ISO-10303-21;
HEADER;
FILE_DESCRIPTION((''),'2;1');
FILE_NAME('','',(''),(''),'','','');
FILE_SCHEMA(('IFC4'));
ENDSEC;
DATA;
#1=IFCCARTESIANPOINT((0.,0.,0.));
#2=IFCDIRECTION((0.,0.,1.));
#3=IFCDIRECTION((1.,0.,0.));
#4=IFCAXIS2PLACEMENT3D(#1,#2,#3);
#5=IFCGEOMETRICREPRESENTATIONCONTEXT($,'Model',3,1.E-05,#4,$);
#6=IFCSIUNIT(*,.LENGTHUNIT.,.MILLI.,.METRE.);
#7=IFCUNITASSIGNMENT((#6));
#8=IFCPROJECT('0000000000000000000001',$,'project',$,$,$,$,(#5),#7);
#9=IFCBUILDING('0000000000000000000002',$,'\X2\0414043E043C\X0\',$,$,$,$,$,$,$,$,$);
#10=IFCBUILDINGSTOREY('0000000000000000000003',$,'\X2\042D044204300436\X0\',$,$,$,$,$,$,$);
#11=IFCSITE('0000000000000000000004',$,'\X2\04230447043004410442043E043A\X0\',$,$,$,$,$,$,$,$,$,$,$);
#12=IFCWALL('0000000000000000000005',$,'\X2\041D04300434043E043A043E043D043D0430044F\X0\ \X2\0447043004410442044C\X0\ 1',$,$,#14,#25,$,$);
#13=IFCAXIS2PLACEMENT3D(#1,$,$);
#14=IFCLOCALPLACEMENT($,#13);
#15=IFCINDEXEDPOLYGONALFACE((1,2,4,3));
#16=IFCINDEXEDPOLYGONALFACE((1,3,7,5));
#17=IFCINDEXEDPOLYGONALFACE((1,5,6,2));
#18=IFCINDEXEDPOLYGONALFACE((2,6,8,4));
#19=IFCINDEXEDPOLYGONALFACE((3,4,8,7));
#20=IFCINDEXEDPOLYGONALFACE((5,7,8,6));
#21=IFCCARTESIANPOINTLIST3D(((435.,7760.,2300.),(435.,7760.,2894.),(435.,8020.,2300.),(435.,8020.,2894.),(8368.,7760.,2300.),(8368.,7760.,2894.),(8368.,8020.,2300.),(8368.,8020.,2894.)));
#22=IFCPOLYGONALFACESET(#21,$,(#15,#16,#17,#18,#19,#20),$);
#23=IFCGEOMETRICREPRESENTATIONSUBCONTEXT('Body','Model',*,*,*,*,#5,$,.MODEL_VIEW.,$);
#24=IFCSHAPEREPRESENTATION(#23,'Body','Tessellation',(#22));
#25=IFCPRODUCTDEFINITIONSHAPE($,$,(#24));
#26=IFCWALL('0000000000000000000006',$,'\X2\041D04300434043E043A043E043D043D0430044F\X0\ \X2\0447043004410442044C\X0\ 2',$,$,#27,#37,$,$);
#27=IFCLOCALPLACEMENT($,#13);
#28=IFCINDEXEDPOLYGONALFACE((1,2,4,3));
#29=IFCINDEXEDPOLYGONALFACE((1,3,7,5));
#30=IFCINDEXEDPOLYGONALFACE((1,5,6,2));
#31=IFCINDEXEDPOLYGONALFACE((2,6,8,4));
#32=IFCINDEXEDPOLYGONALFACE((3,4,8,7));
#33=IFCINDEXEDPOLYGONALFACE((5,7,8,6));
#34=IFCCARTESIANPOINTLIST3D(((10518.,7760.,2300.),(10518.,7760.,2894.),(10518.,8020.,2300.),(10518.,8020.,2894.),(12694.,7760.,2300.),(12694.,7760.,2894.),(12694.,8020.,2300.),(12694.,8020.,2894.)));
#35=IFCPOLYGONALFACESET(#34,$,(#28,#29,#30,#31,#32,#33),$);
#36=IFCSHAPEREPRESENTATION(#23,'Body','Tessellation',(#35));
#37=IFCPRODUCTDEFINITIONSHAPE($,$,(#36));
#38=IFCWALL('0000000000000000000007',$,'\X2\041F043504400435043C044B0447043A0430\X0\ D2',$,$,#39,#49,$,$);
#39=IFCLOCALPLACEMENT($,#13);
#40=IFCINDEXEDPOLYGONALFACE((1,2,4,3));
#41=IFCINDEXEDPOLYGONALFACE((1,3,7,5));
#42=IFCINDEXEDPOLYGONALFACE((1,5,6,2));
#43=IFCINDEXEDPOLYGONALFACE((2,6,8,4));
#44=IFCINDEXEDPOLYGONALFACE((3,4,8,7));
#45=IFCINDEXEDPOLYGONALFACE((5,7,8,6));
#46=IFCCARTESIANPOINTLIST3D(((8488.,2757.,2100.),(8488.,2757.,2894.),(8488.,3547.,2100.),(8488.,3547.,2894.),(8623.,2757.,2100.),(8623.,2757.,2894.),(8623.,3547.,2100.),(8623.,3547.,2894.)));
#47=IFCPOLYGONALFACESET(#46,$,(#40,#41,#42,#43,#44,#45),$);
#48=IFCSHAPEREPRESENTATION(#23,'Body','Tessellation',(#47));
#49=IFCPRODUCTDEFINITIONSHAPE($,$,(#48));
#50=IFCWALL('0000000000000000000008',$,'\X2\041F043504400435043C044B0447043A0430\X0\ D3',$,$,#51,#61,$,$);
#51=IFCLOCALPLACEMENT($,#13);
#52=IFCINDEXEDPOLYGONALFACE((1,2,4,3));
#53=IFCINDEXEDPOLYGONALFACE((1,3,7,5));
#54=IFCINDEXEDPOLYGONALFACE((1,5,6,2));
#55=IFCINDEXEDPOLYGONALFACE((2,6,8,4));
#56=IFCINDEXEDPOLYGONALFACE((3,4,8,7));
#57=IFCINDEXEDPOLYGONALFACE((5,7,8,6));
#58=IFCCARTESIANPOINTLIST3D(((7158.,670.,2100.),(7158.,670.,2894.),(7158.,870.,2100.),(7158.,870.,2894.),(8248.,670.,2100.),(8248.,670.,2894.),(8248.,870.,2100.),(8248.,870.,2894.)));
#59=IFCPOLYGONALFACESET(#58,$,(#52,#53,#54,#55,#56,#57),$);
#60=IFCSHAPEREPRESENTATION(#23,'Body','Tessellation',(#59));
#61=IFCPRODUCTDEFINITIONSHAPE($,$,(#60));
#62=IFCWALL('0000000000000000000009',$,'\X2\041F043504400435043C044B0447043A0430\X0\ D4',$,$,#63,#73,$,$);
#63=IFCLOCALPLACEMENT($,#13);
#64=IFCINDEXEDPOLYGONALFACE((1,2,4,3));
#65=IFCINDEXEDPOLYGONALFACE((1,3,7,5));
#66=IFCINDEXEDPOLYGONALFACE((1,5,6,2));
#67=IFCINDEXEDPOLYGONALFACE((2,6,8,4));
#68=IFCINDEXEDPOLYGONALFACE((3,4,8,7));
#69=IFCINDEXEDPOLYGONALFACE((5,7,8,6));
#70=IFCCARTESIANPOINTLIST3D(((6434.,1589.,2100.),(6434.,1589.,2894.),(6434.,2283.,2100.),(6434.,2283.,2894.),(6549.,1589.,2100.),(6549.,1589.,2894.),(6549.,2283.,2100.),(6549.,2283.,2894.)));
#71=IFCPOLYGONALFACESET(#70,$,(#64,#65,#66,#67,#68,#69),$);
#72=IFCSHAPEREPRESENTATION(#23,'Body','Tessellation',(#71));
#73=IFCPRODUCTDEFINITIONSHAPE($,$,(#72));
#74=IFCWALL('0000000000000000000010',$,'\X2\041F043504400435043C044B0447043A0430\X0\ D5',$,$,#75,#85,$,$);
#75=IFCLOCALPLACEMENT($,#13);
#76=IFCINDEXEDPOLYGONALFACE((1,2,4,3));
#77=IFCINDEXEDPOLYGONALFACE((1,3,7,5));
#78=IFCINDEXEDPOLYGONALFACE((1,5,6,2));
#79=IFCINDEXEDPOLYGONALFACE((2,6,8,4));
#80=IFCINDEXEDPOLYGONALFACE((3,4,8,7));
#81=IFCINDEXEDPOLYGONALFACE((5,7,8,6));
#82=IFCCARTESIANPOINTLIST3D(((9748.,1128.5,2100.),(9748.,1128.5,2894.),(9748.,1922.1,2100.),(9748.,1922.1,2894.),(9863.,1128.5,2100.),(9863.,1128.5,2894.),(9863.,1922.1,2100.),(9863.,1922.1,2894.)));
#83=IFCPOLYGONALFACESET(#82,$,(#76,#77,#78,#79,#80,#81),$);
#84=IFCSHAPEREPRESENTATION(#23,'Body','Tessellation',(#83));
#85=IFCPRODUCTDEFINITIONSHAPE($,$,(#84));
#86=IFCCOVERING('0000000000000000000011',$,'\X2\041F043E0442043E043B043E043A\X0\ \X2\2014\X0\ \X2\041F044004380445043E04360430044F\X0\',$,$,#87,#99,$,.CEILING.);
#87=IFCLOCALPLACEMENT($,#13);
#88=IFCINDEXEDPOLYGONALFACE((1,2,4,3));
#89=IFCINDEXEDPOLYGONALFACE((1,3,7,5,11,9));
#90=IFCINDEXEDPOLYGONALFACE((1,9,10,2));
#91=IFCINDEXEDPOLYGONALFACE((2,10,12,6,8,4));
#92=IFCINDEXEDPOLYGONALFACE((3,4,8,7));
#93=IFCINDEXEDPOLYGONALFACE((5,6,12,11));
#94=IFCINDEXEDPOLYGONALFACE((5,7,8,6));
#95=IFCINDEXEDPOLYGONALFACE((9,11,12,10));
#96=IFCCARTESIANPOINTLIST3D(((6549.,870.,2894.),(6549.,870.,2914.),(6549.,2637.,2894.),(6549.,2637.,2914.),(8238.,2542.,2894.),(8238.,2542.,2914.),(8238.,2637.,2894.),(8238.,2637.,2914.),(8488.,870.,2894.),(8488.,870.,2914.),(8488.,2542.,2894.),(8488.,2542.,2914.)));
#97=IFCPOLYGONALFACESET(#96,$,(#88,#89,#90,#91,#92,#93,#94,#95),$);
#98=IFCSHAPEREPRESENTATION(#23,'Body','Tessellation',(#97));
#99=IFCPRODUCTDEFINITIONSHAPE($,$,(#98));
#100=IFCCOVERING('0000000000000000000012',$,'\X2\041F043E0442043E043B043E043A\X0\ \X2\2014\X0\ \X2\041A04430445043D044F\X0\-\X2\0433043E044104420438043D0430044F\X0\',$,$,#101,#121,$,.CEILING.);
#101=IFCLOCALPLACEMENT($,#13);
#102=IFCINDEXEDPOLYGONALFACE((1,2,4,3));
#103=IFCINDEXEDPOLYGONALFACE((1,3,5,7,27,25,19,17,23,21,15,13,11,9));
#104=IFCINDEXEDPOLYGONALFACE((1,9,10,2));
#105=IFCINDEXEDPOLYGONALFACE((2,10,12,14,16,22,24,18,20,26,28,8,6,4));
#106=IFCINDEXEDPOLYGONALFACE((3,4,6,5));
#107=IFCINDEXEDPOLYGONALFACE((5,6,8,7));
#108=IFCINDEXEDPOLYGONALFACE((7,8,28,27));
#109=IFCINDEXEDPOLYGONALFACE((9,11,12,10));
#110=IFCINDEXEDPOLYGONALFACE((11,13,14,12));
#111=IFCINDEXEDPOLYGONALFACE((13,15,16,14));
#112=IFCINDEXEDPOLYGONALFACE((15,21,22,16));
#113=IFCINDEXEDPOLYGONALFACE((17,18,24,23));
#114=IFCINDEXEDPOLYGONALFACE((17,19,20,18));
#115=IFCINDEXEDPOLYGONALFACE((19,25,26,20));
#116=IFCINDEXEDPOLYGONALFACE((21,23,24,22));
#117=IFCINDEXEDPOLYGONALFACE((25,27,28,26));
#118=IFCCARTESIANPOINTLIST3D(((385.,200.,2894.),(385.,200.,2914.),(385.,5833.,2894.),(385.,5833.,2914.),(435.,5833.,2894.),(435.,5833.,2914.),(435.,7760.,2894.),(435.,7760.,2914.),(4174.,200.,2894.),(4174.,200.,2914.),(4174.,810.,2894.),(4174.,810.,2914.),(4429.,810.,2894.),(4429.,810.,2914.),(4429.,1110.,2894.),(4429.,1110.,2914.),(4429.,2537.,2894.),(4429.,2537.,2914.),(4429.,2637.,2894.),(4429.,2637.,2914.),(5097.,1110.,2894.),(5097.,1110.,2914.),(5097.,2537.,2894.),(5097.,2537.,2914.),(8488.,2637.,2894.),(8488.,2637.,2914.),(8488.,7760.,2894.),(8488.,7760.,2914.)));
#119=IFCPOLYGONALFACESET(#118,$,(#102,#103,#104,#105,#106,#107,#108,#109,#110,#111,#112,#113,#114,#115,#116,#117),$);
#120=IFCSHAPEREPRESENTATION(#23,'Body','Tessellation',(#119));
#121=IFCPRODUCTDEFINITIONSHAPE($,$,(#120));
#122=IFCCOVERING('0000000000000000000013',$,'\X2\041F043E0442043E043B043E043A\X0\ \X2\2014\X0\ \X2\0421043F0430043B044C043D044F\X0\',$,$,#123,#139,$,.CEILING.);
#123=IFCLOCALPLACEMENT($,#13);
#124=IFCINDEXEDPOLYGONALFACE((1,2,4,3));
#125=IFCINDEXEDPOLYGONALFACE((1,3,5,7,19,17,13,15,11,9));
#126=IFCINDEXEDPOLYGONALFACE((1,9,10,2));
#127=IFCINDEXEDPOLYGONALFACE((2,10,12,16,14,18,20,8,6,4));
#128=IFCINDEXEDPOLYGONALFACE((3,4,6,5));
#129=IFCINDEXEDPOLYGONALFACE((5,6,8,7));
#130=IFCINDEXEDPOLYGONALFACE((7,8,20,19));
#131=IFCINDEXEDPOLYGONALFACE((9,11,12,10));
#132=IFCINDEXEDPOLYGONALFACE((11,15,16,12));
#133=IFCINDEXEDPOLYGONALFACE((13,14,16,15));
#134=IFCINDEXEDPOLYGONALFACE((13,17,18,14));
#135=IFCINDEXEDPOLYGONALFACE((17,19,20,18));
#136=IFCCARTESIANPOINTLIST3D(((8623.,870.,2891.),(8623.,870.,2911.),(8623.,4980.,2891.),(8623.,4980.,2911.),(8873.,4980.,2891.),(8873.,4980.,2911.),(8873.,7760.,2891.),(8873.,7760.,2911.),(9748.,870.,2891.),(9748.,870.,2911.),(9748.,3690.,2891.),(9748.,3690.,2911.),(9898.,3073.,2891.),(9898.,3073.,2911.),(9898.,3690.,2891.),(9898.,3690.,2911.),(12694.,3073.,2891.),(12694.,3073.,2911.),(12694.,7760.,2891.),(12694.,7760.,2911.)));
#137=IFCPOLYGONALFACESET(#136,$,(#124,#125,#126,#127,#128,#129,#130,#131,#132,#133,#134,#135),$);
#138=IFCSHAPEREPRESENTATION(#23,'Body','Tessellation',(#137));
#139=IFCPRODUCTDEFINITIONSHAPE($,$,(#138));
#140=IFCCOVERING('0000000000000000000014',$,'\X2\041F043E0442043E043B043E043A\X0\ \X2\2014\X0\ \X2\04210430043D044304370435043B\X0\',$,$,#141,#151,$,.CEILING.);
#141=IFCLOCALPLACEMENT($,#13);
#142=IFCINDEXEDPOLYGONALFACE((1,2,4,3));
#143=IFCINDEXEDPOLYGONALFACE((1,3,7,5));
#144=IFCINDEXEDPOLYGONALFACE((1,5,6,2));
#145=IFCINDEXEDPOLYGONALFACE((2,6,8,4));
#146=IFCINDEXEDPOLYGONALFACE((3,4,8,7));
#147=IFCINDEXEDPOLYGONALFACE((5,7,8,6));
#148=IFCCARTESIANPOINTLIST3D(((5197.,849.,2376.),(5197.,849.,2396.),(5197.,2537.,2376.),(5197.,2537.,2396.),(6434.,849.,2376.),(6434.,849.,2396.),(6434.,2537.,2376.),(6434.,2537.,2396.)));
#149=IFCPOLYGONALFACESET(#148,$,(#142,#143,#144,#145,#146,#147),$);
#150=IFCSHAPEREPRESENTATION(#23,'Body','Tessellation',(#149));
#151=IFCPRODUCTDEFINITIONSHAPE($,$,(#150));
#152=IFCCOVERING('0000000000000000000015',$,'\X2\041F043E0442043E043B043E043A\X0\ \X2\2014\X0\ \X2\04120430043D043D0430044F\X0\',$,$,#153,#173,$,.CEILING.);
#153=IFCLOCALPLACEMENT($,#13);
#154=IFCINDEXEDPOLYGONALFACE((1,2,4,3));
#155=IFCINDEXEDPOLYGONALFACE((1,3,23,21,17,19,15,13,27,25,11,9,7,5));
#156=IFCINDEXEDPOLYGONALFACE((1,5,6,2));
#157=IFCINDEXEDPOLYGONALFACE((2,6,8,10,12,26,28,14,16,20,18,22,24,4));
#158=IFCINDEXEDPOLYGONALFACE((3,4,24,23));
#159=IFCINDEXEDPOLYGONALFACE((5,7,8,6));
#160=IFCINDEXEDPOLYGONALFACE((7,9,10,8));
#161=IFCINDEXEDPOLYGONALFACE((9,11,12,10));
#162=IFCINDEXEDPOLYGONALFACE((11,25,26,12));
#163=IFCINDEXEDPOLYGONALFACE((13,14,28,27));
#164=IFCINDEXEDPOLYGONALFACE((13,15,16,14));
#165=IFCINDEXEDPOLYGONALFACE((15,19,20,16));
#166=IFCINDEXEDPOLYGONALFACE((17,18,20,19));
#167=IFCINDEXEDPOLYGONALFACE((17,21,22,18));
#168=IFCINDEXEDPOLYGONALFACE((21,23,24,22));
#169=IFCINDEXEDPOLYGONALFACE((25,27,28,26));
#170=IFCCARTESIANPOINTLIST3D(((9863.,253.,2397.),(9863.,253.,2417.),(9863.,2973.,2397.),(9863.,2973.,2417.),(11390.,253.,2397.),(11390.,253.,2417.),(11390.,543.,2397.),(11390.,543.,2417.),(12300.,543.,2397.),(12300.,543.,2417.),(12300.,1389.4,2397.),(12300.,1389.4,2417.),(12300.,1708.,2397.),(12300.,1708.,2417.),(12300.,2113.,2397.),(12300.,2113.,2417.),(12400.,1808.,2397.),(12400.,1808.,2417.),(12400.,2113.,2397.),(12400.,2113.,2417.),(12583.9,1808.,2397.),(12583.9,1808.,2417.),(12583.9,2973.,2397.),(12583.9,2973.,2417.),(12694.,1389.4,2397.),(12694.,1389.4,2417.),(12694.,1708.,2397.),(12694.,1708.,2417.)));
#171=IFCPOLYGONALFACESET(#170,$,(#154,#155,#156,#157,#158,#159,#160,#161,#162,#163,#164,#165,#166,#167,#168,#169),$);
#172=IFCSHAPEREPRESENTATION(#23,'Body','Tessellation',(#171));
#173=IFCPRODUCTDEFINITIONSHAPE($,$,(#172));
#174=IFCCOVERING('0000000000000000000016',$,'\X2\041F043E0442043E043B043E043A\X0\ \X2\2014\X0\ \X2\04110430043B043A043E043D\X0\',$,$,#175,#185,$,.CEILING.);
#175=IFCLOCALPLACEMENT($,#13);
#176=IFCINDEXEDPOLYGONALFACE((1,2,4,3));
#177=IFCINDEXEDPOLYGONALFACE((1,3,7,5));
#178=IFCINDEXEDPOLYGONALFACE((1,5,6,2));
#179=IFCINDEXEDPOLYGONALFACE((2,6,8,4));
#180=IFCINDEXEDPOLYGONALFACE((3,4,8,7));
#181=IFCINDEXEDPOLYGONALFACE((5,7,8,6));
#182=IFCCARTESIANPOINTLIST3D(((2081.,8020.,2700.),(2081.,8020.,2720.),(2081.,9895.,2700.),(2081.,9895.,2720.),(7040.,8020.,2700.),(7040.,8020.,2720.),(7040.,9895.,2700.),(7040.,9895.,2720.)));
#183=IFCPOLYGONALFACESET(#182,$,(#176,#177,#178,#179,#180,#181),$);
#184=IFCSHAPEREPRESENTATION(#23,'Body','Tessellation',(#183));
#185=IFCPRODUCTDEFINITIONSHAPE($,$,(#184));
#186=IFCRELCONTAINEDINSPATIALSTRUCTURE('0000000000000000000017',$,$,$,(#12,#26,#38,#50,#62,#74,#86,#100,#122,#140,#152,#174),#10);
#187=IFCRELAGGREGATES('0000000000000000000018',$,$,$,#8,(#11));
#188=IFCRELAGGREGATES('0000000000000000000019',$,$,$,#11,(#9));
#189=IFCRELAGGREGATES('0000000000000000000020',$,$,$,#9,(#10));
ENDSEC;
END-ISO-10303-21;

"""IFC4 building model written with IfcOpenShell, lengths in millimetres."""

from ifc_helpers import new_model, si_unit, frame, origin, origin_with_axes, place, context, subcontext, project, spatial, polyline, outline, extrude, element, save


model = new_model("IFC4")

# Units and contexts
model_context = context("Model", 3, precision=1e-05, world=origin_with_axes())
body_context = subcontext(model_context, "Body", "Model", "MODEL_VIEW")
ifc_project = project(units=[si_unit("LENGTHUNIT", "METRE", prefix="MILLI")], contexts=[model_context])

# Site, building, storey
site = spatial("IfcSite", under=ifc_project, Name="Участок")
building = spatial("IfcBuilding", under=site, Name="Дом")
storey = spatial("IfcBuildingStorey", under=building, Name="Этаж")

# Walls
wall_1_placement = place(None, frame((0.0, 0.0, 2300.0), z_axis=(0.0, 0.0, 1.0), x_axis=(1.0, 0.0, 0.0)))
element("IfcWall", 1, at=wall_1_placement, inside=storey, Name="Надоконная часть 1", context=body_context, shape_type="SweptSolid", body=[
    extrude(outline(polyline([(8368.0, 7760.0), (435.0, 7760.0), (435.0, 8020.0), (8368.0, 8020.0), (8368.0, 7760.0)])), origin(), (0.0, 0.0, 1.0), 594.0),
])
wall_2_placement = place(None, frame((0.0, 0.0, 2300.0), z_axis=(0.0, 0.0, 1.0), x_axis=(1.0, 0.0, 0.0)))
element("IfcWall", 2, at=wall_2_placement, inside=storey, Name="Надоконная часть 2", context=body_context, shape_type="SweptSolid", body=[
    extrude(outline(polyline([(12694.0, 7760.0), (10518.0, 7760.0), (10518.0, 8020.0), (12694.0, 8020.0), (12694.0, 7760.0)])), origin(), (0.0, 0.0, 1.0), 594.0),
])
wall_3_placement = place(None, frame((0.0, 0.0, 2100.0), z_axis=(0.0, 0.0, 1.0), x_axis=(1.0, 0.0, 0.0)))
element("IfcWall", 3, at=wall_3_placement, inside=storey, Name="Перемычка D2", context=body_context, shape_type="SweptSolid", body=[
    extrude(outline(polyline([(8488.0, 3547.0), (8623.0, 3547.0), (8623.0, 2757.0), (8488.0, 2757.0), (8488.0, 3547.0)])), origin(), (0.0, 0.0, 1.0), 794.0),
])
wall_4_placement = place(None, frame((0.0, 0.0, 2100.0), z_axis=(0.0, 0.0, 1.0), x_axis=(1.0, 0.0, 0.0)))
element("IfcWall", 4, at=wall_4_placement, inside=storey, Name="Перемычка D3", context=body_context, shape_type="SweptSolid", body=[
    extrude(outline(polyline([(7158.0, 670.0), (7158.0, 870.0), (8248.0, 870.0), (8248.0, 670.0), (7158.0, 670.0)])), origin(), (0.0, 0.0, 1.0), 794.0),
])
wall_5_placement = place(None, frame((0.0, 0.0, 2100.0), z_axis=(0.0, 0.0, 1.0), x_axis=(1.0, 0.0, 0.0)))
element("IfcWall", 5, at=wall_5_placement, inside=storey, Name="Перемычка D4", context=body_context, shape_type="SweptSolid", body=[
    extrude(outline(polyline([(6549.0, 2283.0), (6549.0, 1589.0), (6434.0, 1589.0), (6434.0, 2283.0), (6549.0, 2283.0)])), origin(), (0.0, 0.0, 1.0), 794.0),
])
wall_6_placement = place(None, frame((0.0, 0.0, 2100.0), z_axis=(0.0, 0.0, 1.0), x_axis=(1.0, 0.0, 0.0)))
element("IfcWall", 6, at=wall_6_placement, inside=storey, Name="Перемычка D5", context=body_context, shape_type="SweptSolid", body=[
    extrude(outline(polyline([(9748.0, 1922.1), (9748.0, 1128.5), (9863.0, 1128.5), (9863.0, 1922.1), (9748.0, 1922.1)])), origin(), (0.0, 0.0, 1.0), 794.0),
])

# Coverings
covering_1_placement = place(None, frame((0.0, 0.0, 2894.0), z_axis=(0.0, 0.0, 1.0), x_axis=(1.0, 0.0, 0.0)))
element("IfcCovering", 7, at=covering_1_placement, inside=storey, Name="Потолок — Прихожая", PredefinedType="CEILING", context=body_context, shape_type="SweptSolid", body=[
    extrude(outline(polyline([(8238.0, 2637.0), (8238.0, 2542.0), (8488.0, 2542.0), (8488.0, 870.0), (6549.0, 870.0), (6549.0, 2637.0), (8238.0, 2637.0)])), origin(), (0.0, 0.0, 1.0), 20.0),
])
covering_2_placement = place(None, frame((0.0, 0.0, 2894.0), z_axis=(0.0, 0.0, 1.0), x_axis=(1.0, 0.0, 0.0)))
element("IfcCovering", 8, at=covering_2_placement, inside=storey, Name="Потолок — Кухня-гостиная", PredefinedType="CEILING", context=body_context, shape_type="SweptSolid", body=[
    extrude(outline(polyline([(435.0, 7760.0), (8488.0, 7760.0), (8488.0, 2637.0), (4429.0, 2637.0), (4429.0, 2537.0), (5097.0, 2537.0), (5097.0, 1110.0), (4429.0, 1110.0), (4429.0, 810.0), (4174.0, 810.0), (4174.0, 200.0), (385.0, 200.0), (385.0, 5833.0), (435.0, 5833.0), (435.0, 7760.0)])), origin(), (0.0, 0.0, 1.0), 20.0),
])
covering_3_placement = place(None, frame((0.0, 0.0, 2891.0), z_axis=(0.0, 0.0, 1.0), x_axis=(1.0, 0.0, 0.0)))
element("IfcCovering", 9, at=covering_3_placement, inside=storey, Name="Потолок — Спальня", PredefinedType="CEILING", context=body_context, shape_type="SweptSolid", body=[
    extrude(outline(polyline([(9748.0, 3690.0), (9748.0, 870.0), (8623.0, 870.0), (8623.0, 4980.0), (8873.0, 4980.0), (8873.0, 7760.0), (12694.0, 7760.0), (12694.0, 3073.0), (9898.0, 3073.0), (9898.0, 3690.0), (9748.0, 3690.0)])), origin(), (0.0, 0.0, 1.0), 20.0),
])
covering_4_placement = place(None, frame((0.0, 0.0, 2376.0), z_axis=(0.0, 0.0, 1.0), x_axis=(1.0, 0.0, 0.0)))
element("IfcCovering", 10, at=covering_4_placement, inside=storey, Name="Потолок — Санузел", PredefinedType="CEILING", context=body_context, shape_type="SweptSolid", body=[
    extrude(outline(polyline([(5197.0, 2537.0), (6434.0, 2537.0), (6434.0, 849.0), (5197.0, 849.0), (5197.0, 2537.0)])), origin(), (0.0, 0.0, 1.0), 20.0),
])
covering_5_placement = place(None, frame((0.0, 0.0, 2397.0), z_axis=(0.0, 0.0, 1.0), x_axis=(1.0, 0.0, 0.0)))
element("IfcCovering", 11, at=covering_5_placement, inside=storey, Name="Потолок — Ванная", PredefinedType="CEILING", context=body_context, shape_type="SweptSolid", body=[
    extrude(outline(polyline([(9863.0, 253.0), (9863.0, 2973.0), (12583.9, 2973.0), (12583.9, 1808.0), (12400.0, 1808.0), (12400.0, 2113.0), (12300.0, 2113.0), (12300.0, 1708.0), (12694.0, 1708.0), (12694.0, 1389.4), (12300.0, 1389.4), (12300.0, 543.0), (11390.0, 543.0), (11390.0, 253.0), (9863.0, 253.0)])), origin(), (0.0, 0.0, 1.0), 20.0),
])
covering_6_placement = place(None, frame((0.0, 0.0, 2700.0), z_axis=(0.0, 0.0, 1.0), x_axis=(1.0, 0.0, 0.0)))
element("IfcCovering", 12, at=covering_6_placement, inside=storey, Name="Потолок — Балкон", PredefinedType="CEILING", context=body_context, shape_type="SweptSolid", body=[
    extrude(outline(polyline([(2081.0, 8020.0), (2081.0, 9895.0), (7040.0, 9895.0), (7040.0, 8020.0), (2081.0, 8020.0)])), origin(), (0.0, 0.0, 1.0), 20.0),
])

save(model, "model.ifc")
